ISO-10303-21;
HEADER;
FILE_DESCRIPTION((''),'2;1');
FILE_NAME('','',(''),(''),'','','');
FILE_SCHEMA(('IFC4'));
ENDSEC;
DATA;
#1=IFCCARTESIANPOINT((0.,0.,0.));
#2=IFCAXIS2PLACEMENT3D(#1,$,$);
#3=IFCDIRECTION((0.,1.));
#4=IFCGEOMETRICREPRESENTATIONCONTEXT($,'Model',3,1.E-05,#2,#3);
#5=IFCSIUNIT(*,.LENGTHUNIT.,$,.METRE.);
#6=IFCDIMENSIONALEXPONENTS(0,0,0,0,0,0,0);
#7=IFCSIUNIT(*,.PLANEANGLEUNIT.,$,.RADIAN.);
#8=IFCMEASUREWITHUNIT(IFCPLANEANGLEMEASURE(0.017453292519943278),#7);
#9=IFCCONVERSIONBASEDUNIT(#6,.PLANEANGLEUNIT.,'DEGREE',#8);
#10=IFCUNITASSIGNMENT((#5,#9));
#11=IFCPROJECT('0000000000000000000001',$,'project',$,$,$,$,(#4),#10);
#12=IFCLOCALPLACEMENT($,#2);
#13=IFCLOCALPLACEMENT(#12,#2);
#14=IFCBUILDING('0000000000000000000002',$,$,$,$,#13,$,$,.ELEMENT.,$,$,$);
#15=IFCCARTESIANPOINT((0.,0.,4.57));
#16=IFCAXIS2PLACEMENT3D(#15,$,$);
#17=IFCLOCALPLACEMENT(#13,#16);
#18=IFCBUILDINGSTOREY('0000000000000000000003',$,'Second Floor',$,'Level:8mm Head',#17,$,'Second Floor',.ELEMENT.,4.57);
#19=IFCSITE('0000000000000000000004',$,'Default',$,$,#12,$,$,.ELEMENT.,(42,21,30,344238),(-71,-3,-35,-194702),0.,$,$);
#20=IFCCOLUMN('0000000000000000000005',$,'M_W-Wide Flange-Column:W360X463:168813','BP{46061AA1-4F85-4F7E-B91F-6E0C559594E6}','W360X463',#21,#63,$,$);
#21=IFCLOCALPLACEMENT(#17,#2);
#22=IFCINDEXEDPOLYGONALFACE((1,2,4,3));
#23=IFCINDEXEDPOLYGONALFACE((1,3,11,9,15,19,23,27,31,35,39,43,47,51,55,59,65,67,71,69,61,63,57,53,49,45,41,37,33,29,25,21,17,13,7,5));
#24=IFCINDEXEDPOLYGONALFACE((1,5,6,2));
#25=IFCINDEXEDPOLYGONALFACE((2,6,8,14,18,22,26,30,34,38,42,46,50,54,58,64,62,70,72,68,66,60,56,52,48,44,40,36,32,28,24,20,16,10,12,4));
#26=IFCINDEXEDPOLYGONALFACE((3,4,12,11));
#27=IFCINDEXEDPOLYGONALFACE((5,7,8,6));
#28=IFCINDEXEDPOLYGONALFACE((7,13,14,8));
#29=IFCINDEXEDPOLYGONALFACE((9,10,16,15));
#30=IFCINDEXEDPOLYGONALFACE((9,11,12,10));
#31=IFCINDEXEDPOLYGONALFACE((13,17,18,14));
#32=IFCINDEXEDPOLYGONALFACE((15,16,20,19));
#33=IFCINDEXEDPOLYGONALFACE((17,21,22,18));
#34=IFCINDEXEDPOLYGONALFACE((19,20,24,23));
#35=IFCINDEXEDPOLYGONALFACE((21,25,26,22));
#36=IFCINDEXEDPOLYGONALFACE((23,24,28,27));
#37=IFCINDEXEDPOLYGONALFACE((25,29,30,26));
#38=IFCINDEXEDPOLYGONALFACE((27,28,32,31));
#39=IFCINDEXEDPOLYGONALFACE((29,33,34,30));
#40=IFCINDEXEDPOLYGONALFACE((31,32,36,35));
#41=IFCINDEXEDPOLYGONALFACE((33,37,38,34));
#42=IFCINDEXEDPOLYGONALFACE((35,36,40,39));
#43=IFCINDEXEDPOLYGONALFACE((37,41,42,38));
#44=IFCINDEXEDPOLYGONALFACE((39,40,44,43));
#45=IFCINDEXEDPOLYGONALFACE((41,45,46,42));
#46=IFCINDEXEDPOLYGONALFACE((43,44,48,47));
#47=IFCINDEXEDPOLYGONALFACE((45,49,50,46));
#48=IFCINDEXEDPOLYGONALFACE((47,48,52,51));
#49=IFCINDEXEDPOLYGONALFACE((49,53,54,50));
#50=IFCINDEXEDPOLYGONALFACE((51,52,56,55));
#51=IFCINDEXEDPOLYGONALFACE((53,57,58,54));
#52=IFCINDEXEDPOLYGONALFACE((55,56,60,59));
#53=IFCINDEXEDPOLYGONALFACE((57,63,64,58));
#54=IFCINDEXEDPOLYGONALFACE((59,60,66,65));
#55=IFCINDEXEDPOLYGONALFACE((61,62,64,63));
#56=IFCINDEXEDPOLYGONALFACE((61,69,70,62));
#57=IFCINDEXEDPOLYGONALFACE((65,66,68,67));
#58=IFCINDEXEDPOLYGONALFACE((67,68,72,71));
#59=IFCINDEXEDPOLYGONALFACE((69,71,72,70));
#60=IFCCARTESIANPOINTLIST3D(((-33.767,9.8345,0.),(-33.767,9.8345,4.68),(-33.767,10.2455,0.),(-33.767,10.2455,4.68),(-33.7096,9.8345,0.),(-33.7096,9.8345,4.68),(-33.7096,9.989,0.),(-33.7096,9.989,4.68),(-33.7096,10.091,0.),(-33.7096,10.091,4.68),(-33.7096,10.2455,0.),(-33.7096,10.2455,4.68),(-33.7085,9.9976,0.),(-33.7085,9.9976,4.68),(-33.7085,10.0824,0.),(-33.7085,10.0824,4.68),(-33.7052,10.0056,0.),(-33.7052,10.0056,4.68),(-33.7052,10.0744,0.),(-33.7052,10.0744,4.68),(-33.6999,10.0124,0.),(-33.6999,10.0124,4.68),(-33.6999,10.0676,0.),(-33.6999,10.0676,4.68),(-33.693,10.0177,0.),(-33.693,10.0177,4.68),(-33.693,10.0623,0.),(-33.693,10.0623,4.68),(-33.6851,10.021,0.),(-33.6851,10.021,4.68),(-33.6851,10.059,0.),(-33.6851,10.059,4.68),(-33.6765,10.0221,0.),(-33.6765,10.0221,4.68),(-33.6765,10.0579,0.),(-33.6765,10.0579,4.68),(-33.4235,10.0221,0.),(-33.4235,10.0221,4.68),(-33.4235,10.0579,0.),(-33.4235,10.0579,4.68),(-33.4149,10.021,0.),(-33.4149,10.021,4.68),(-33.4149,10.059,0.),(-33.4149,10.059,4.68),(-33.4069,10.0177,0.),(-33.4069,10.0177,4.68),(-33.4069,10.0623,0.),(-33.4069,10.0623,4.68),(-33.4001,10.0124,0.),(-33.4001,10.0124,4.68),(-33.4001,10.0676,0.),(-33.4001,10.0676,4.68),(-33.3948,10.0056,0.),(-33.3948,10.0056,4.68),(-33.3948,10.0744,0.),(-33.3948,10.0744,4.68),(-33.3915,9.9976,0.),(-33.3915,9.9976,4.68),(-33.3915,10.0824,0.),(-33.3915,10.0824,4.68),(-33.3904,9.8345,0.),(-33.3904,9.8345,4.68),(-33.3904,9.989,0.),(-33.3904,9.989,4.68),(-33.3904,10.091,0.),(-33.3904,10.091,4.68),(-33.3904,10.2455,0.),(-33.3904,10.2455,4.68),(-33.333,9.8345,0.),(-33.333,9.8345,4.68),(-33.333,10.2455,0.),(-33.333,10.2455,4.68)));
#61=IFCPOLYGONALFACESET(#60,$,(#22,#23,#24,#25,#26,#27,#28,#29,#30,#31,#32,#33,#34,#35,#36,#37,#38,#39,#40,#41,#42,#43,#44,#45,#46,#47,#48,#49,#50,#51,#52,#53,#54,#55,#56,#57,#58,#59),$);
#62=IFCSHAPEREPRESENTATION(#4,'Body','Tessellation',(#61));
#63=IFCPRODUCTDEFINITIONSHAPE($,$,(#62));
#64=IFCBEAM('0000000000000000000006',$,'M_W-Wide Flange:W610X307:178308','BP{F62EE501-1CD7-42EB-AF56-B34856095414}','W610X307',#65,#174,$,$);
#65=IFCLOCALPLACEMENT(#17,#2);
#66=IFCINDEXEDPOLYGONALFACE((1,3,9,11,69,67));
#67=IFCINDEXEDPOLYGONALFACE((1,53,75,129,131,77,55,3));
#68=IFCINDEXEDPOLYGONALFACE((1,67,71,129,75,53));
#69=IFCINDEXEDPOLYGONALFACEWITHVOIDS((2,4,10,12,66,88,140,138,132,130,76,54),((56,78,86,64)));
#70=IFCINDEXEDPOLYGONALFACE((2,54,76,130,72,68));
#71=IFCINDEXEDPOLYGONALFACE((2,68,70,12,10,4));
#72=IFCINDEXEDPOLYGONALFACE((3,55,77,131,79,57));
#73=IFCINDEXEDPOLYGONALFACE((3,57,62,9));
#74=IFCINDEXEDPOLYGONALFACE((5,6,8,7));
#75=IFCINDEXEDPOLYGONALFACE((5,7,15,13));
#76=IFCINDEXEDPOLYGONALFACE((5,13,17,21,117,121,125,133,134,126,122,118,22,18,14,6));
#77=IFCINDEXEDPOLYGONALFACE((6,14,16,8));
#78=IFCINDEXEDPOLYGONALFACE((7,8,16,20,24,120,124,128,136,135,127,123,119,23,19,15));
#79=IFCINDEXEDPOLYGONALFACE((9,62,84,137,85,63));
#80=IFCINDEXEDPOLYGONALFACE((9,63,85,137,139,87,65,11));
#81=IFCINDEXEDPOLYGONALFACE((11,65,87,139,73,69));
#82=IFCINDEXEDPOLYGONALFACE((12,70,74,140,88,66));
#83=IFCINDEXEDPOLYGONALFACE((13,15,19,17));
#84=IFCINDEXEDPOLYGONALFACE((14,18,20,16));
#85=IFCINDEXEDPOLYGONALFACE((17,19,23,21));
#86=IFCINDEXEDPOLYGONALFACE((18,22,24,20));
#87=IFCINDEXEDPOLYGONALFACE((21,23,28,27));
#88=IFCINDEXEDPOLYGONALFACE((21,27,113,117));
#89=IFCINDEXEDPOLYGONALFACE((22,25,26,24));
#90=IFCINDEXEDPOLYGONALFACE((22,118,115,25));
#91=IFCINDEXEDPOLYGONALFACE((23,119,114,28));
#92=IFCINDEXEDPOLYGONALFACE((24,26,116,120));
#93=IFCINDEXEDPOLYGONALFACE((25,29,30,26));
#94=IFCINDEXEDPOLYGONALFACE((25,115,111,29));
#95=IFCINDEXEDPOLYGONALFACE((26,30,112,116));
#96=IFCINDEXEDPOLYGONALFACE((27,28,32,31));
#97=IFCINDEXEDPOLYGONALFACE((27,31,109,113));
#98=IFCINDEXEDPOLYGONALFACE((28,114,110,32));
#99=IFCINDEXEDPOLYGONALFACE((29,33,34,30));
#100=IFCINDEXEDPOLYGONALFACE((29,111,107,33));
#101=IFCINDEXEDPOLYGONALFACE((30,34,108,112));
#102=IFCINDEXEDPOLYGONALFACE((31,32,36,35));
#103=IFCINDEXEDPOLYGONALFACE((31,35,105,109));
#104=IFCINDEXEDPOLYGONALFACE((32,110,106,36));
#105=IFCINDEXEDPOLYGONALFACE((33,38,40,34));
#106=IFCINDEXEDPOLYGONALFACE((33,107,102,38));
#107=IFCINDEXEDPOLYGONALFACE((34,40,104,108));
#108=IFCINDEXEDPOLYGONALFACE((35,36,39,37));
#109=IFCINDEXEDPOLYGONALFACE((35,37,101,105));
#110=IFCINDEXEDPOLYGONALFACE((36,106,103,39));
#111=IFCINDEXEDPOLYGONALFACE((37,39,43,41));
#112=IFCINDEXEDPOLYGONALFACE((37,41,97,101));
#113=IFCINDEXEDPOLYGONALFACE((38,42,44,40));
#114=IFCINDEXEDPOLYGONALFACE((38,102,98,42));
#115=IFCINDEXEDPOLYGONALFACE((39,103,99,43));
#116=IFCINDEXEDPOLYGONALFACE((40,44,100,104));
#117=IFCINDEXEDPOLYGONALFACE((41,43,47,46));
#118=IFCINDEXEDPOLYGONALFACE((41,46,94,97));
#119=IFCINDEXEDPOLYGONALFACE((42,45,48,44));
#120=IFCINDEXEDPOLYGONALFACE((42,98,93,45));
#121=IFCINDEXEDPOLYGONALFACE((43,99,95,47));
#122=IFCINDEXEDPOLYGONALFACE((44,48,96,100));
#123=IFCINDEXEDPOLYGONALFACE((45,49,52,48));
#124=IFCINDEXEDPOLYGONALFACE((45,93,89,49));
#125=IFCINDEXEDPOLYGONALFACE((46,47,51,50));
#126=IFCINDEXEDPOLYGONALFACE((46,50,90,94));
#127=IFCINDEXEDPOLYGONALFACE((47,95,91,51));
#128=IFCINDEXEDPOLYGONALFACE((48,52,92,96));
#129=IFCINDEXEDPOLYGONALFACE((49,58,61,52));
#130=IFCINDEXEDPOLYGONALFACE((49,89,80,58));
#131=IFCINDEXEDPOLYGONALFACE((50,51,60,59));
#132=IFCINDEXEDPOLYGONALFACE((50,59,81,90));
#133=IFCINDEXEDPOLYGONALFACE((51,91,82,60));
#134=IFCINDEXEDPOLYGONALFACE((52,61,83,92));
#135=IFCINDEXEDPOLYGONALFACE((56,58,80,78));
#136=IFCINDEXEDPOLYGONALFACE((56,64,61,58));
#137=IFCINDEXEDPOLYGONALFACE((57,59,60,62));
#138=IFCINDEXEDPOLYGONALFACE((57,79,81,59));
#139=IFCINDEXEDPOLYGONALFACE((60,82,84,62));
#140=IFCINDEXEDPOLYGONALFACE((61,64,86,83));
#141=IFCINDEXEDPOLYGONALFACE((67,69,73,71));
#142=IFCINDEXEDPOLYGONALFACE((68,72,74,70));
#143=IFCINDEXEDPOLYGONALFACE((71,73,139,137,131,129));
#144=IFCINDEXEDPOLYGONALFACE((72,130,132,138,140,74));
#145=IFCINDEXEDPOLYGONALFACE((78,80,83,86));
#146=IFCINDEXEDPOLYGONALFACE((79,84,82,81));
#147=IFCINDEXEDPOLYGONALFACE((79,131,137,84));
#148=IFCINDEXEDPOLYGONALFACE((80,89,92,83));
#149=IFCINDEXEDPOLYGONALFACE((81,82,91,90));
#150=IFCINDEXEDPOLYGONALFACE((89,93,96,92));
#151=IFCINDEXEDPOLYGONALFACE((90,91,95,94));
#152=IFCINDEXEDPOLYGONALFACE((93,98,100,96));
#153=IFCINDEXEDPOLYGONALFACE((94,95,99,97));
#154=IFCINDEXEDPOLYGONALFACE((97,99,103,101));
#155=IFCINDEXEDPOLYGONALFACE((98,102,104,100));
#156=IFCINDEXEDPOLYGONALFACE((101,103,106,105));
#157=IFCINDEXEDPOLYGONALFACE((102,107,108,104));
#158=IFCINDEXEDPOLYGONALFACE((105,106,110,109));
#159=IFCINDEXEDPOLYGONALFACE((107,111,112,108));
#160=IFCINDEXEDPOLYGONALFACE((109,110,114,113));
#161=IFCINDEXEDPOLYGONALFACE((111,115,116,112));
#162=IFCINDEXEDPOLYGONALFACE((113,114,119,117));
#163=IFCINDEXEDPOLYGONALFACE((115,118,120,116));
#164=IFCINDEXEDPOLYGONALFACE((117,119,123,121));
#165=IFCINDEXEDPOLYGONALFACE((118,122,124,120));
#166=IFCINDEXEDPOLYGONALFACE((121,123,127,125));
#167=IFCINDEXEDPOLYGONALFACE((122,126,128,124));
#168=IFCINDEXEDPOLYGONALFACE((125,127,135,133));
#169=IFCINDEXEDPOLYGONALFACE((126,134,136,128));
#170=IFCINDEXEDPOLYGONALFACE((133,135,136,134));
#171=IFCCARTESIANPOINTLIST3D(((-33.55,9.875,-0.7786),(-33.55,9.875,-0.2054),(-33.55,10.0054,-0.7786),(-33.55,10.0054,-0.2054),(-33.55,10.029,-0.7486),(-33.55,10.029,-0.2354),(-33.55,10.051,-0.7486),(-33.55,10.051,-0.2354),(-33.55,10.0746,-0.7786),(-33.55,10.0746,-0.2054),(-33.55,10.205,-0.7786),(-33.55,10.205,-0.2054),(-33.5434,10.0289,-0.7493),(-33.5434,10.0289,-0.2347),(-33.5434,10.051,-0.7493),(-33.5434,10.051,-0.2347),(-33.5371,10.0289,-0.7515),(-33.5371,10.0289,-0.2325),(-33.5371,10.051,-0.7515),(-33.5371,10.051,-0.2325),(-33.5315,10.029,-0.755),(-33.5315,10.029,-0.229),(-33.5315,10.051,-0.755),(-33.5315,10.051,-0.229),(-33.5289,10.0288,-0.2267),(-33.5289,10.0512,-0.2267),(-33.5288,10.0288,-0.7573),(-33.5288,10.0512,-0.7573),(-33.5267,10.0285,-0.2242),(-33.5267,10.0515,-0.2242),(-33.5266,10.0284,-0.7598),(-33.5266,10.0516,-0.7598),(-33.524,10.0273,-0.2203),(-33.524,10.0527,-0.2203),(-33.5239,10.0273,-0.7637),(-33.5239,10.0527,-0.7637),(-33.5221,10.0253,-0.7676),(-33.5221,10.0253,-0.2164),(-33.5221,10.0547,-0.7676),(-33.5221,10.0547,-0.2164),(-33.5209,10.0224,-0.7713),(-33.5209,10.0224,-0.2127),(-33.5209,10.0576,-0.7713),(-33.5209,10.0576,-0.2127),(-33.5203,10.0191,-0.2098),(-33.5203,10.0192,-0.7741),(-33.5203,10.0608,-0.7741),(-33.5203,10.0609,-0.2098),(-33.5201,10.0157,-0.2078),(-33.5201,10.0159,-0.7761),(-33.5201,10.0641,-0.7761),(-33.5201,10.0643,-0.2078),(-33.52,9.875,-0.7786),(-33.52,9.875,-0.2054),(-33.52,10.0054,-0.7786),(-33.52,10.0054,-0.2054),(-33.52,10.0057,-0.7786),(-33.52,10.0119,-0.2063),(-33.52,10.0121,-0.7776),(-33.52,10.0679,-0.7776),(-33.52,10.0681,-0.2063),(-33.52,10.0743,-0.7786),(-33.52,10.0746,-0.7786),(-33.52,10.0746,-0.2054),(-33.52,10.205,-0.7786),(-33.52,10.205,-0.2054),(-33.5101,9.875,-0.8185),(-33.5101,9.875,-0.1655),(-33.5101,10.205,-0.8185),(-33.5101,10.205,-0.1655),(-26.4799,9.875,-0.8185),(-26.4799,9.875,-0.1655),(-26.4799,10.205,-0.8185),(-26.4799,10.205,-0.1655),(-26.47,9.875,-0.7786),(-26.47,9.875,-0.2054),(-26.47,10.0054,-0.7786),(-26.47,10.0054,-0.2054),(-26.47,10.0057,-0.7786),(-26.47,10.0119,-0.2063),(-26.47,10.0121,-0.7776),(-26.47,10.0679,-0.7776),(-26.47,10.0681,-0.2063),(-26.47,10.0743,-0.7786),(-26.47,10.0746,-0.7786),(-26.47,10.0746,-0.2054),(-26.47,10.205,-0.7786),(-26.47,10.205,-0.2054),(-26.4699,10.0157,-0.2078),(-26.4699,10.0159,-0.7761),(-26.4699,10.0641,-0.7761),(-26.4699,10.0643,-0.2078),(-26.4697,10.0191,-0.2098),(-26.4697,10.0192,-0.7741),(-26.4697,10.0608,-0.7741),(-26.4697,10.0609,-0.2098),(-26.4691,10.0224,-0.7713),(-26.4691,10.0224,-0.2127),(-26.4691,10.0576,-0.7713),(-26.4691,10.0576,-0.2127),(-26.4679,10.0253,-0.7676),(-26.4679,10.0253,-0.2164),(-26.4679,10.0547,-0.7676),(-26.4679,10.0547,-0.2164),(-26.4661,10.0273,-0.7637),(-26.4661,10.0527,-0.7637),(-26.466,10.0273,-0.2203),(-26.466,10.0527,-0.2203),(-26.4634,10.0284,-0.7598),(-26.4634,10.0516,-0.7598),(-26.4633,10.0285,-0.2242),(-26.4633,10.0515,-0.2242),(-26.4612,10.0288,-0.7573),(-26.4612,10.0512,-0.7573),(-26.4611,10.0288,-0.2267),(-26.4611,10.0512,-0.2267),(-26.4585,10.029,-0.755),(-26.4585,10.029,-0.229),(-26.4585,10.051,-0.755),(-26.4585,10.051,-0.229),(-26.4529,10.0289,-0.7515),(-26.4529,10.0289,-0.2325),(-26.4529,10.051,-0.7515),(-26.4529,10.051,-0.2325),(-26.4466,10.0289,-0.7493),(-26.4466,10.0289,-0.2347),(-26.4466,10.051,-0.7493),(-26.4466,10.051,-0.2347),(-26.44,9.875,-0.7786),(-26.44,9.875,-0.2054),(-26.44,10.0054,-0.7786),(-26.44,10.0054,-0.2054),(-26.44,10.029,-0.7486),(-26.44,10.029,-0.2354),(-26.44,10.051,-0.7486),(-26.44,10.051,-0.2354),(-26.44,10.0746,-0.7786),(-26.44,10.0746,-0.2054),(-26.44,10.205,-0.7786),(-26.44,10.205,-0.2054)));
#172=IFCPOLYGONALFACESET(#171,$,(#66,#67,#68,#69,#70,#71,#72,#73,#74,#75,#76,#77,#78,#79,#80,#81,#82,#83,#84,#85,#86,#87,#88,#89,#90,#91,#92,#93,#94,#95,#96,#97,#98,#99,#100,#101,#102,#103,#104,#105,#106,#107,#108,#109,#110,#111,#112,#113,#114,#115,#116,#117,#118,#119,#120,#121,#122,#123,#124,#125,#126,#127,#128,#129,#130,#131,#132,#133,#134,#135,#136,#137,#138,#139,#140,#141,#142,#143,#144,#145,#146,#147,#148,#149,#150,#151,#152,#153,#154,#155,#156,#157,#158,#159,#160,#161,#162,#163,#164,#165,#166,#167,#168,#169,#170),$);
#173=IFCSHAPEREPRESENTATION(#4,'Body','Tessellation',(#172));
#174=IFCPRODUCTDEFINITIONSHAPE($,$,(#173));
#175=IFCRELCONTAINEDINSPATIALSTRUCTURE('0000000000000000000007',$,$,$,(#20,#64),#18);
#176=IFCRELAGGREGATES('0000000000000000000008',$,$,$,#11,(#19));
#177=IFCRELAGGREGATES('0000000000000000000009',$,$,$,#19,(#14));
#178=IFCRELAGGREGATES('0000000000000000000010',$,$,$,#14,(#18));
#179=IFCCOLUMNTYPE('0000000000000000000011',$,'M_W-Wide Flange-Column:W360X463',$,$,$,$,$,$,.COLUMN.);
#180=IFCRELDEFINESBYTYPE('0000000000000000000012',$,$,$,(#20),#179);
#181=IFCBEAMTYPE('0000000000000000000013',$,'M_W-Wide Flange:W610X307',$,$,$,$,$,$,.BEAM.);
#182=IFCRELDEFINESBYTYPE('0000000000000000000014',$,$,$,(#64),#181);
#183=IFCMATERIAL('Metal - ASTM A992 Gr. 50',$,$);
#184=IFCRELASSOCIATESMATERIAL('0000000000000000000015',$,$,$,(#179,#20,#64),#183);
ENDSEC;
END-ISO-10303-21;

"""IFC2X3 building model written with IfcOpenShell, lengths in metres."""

from ifc_helpers import new_model, entity, si_unit, converted_unit, point, direction, frame, frame_2d, origin, origin_2d, place, context, project, spatial, polyline, circle_curve, line_curve, trimmed, segment, composite_curve, i_section, outline, extrude, material, type_object, element, save


model = new_model("IFC2X3")

# Units and contexts
model_context = context("Model", 3, precision=1e-05, world=origin(), true_north=direction((0.0, 1.0)))
ifc_project = project(units=[si_unit("LENGTHUNIT", "METRE"), converted_unit("PLANEANGLEUNIT", "DEGREE", entity("IfcPlaneAngleMeasure", 0.017453292519943278), si_unit("PLANEANGLEUNIT", "RADIAN"), dimensions=[0, 0, 0, 0, 0, 0, 0])], contexts=[model_context])

# Site, building, storey
site_placement = place(None, origin())
site = spatial("IfcSite", under=ifc_project, at=site_placement, Name="Default", CompositionType="ELEMENT", RefLatitude=(42, 21, 30, 344238), RefLongitude=(-71, -3, -35, -194702), RefElevation=0.0)
building_placement = place(site_placement, origin())
building = spatial("IfcBuilding", under=site, at=building_placement, CompositionType="ELEMENT")
storey_placement = place(building_placement, frame((0.0, 0.0, 4.57)))
storey = spatial("IfcBuildingStorey", under=building, at=storey_placement, Name="Second Floor", ObjectType="Level:8mm Head", LongName="Second Floor", CompositionType="ELEMENT", Elevation=4.57)

# Column
ifc_material_1 = material(Name="Metal - ASTM A992 Gr. 50")
column_type = type_object("IfcColumnType", Name="M_W-Wide Flange-Column:W360X463", PredefinedType="COLUMN", material=ifc_material_1)
column_placement = place(storey_placement, frame((-33.55, 10.04, 4.68), z_axis=(0.0, 0.0, 1.0), x_axis=(0.0, -1.0, 0.0)))
element("IfcColumn", 1, at=column_placement, inside=storey, type_object=column_type, material=ifc_material_1, Name="M_W-Wide Flange-Column:W360X463:168813", Description="BP{46061AA1-4F85-4F7E-B91F-6E0C559594E6}", ObjectType="W360X463", context=model_context, shape_type="SweptSolid", body=[
    extrude(i_section(OverallWidth=0.411, OverallDepth=0.434, WebThickness=0.0358, FlangeThickness=0.0574, FilletRadius=0.0331, at=origin_2d()), origin(), (0.0, 0.0, -1.0), 4.68),
])

# Beam, openings
beam_type_1 = type_object("IfcBeamType", Name="M_W-Wide Flange:W610X307", PredefinedType="BEAM")
beam_1_placement = place(storey_placement, frame((-33.55, 10.04, -0.492), z_axis=(-1.0, 0.0, 0.0), x_axis=(0.0, -1.0, 0.0)))
beam_1 = element("IfcBeam", 2, at=beam_1_placement, inside=storey, type_object=beam_type_1, material=ifc_material_1, Name="M_W-Wide Flange:W610X307:178308", Description="BP{F62EE501-1CD7-42EB-AF56-B34856095414}", ObjectType="W610X307", context=model_context, shape_type="SweptSolid", body=[
    extrude(i_section(OverallWidth=0.33, OverallDepth=0.653, WebThickness=0.0221, FlangeThickness=0.0399, FilletRadius=0.0236, at=origin_2d()), origin(), (0.0, 0.0, -1.0), 7.11),
])
opening_1_placement = place(beam_1_placement, frame((0.2651, 0.3265, 0.0), z_axis=(-1.0, 0.0, 0.0), x_axis=(0.0, 0.0, 1.0)))
element("IfcOpeningElement", 3, at=opening_1_placement, cuts=beam_1, ObjectType="Opening", context=model_context, shape_type="SweptSolid", body=[
    extrude(outline(polyline([(0.0, -0.0399), (0.0, 0.0), (-0.0399, 0.0), (0.0, -0.0399)])), origin(), (0.0, 0.0, 1.0), 0.5302),
])
opening_2_placement = place(beam_1_placement, frame((-0.2651, 0.3265, 0.0), z_axis=(1.0, 0.0, 0.0), x_axis=(0.0, 0.0, -1.0)))
element("IfcOpeningElement", 4, at=opening_2_placement, cuts=beam_1, ObjectType="Opening", context=model_context, shape_type="SweptSolid", body=[
    extrude(outline(polyline([(0.0, -0.6131), (0.0, -0.653), (0.0399, -0.653), (0.0, -0.6131)])), origin(), (0.0, 0.0, 1.0), 0.5302),
])
opening_3_placement = place(beam_1_placement, frame((0.2651, 0.3265, 0.0), z_axis=(-1.0, 0.0, 0.0), x_axis=(0.0, 0.0, 1.0)))
element("IfcOpeningElement", 5, at=opening_3_placement, cuts=beam_1, ObjectType="Opening", context=model_context, shape_type="SweptSolid", body=[
    extrude(outline(composite_curve([segment(trimmed(circle_curve(frame_2d((0.0, -0.0399), x_axis=(1.0, 0.0)), 0.03), [point((-0.03, -0.0399))], [point((0.03, -0.0399))], True, "CARTESIAN"), True, "CONTINUOUS"), segment(trimmed(line_curve((0.03, -0.0399), (-1.0, 0.0), 0.06), [point((0.03, -0.0399))], [point((-0.03, -0.0399))], True, "CARTESIAN"), True, "CONTINUOUS")], self_intersect="UNKNOWN")), origin(), (0.0, 0.0, 1.0), 0.5302),
])
opening_4_placement = place(beam_1_placement, frame((-0.2651, 0.3265, 0.0), z_axis=(1.0, 0.0, 0.0), x_axis=(0.0, 0.0, -1.0)))
element("IfcOpeningElement", 6, at=opening_4_placement, cuts=beam_1, ObjectType="Opening", context=model_context, shape_type="SweptSolid", body=[
    extrude(outline(composite_curve([segment(trimmed(circle_curve(frame_2d((0.0, -0.6131), x_axis=(1.0, 0.0)), 0.03), [point((0.03, -0.6131))], [point((-0.03, -0.6131))], True, "CARTESIAN"), True, "CONTINUOUS"), segment(trimmed(line_curve((-0.03, -0.6131), (1.0, 0.0), 0.06), [point((-0.03, -0.6131))], [point((0.03, -0.6131))], True, "CARTESIAN"), True, "CONTINUOUS")], self_intersect="UNKNOWN")), origin(), (0.0, 0.0, 1.0), 0.5302),
])
opening_5_placement = place(beam_1_placement, frame((-0.2651, 0.3265, -7.11), z_axis=(1.0, 0.0, 0.0), x_axis=(0.0, 0.0, -1.0)))
element("IfcOpeningElement", 7, at=opening_5_placement, cuts=beam_1, ObjectType="Opening", context=model_context, shape_type="SweptSolid", body=[
    extrude(outline(polyline([(0.0, -0.0399), (0.0, 0.0), (-0.0399, 0.0), (0.0, -0.0399)])), origin(), (0.0, 0.0, 1.0), 0.5302),
])
opening_6_placement = place(beam_1_placement, frame((0.2651, 0.3265, -7.11), z_axis=(-1.0, 0.0, 0.0), x_axis=(0.0, 0.0, 1.0)))
element("IfcOpeningElement", 8, at=opening_6_placement, cuts=beam_1, ObjectType="Opening", context=model_context, shape_type="SweptSolid", body=[
    extrude(outline(polyline([(0.0, -0.6131), (0.0, -0.653), (0.0399, -0.653), (0.0, -0.6131)])), origin(), (0.0, 0.0, 1.0), 0.5302),
])
opening_7_placement = place(beam_1_placement, frame((-0.2651, 0.3265, -7.11), z_axis=(1.0, 0.0, 0.0), x_axis=(0.0, 0.0, -1.0)))
element("IfcOpeningElement", 9, at=opening_7_placement, cuts=beam_1, ObjectType="Opening", context=model_context, shape_type="SweptSolid", body=[
    extrude(outline(composite_curve([segment(trimmed(circle_curve(frame_2d((0.0, -0.0399), x_axis=(1.0, 0.0)), 0.03), [point((-0.03, -0.0399))], [point((0.03, -0.0399))], True, "CARTESIAN"), True, "CONTINUOUS"), segment(trimmed(line_curve((0.03, -0.0399), (-1.0, 0.0), 0.06), [point((0.03, -0.0399))], [point((-0.03, -0.0399))], True, "CARTESIAN"), True, "CONTINUOUS")], self_intersect="UNKNOWN")), origin(), (0.0, 0.0, 1.0), 0.5302),
])
opening_8_placement = place(beam_1_placement, frame((0.2651, 0.3265, -7.11), z_axis=(-1.0, 0.0, 0.0), x_axis=(0.0, 0.0, 1.0)))
element("IfcOpeningElement", 10, at=opening_8_placement, cuts=beam_1, ObjectType="Opening", context=model_context, shape_type="SweptSolid", body=[
    extrude(outline(composite_curve([segment(trimmed(circle_curve(frame_2d((0.0, -0.6131), x_axis=(1.0, 0.0)), 0.03), [point((0.03, -0.6131))], [point((-0.03, -0.6131))], True, "CARTESIAN"), True, "CONTINUOUS"), segment(trimmed(line_curve((-0.03, -0.6131), (1.0, 0.0), 0.06), [point((-0.03, -0.6131))], [point((0.03, -0.6131))], True, "CARTESIAN"), True, "CONTINUOUS")], self_intersect="UNKNOWN")), origin(), (0.0, 0.0, 1.0), 0.5302),
])

save(model, "model.ifc")
